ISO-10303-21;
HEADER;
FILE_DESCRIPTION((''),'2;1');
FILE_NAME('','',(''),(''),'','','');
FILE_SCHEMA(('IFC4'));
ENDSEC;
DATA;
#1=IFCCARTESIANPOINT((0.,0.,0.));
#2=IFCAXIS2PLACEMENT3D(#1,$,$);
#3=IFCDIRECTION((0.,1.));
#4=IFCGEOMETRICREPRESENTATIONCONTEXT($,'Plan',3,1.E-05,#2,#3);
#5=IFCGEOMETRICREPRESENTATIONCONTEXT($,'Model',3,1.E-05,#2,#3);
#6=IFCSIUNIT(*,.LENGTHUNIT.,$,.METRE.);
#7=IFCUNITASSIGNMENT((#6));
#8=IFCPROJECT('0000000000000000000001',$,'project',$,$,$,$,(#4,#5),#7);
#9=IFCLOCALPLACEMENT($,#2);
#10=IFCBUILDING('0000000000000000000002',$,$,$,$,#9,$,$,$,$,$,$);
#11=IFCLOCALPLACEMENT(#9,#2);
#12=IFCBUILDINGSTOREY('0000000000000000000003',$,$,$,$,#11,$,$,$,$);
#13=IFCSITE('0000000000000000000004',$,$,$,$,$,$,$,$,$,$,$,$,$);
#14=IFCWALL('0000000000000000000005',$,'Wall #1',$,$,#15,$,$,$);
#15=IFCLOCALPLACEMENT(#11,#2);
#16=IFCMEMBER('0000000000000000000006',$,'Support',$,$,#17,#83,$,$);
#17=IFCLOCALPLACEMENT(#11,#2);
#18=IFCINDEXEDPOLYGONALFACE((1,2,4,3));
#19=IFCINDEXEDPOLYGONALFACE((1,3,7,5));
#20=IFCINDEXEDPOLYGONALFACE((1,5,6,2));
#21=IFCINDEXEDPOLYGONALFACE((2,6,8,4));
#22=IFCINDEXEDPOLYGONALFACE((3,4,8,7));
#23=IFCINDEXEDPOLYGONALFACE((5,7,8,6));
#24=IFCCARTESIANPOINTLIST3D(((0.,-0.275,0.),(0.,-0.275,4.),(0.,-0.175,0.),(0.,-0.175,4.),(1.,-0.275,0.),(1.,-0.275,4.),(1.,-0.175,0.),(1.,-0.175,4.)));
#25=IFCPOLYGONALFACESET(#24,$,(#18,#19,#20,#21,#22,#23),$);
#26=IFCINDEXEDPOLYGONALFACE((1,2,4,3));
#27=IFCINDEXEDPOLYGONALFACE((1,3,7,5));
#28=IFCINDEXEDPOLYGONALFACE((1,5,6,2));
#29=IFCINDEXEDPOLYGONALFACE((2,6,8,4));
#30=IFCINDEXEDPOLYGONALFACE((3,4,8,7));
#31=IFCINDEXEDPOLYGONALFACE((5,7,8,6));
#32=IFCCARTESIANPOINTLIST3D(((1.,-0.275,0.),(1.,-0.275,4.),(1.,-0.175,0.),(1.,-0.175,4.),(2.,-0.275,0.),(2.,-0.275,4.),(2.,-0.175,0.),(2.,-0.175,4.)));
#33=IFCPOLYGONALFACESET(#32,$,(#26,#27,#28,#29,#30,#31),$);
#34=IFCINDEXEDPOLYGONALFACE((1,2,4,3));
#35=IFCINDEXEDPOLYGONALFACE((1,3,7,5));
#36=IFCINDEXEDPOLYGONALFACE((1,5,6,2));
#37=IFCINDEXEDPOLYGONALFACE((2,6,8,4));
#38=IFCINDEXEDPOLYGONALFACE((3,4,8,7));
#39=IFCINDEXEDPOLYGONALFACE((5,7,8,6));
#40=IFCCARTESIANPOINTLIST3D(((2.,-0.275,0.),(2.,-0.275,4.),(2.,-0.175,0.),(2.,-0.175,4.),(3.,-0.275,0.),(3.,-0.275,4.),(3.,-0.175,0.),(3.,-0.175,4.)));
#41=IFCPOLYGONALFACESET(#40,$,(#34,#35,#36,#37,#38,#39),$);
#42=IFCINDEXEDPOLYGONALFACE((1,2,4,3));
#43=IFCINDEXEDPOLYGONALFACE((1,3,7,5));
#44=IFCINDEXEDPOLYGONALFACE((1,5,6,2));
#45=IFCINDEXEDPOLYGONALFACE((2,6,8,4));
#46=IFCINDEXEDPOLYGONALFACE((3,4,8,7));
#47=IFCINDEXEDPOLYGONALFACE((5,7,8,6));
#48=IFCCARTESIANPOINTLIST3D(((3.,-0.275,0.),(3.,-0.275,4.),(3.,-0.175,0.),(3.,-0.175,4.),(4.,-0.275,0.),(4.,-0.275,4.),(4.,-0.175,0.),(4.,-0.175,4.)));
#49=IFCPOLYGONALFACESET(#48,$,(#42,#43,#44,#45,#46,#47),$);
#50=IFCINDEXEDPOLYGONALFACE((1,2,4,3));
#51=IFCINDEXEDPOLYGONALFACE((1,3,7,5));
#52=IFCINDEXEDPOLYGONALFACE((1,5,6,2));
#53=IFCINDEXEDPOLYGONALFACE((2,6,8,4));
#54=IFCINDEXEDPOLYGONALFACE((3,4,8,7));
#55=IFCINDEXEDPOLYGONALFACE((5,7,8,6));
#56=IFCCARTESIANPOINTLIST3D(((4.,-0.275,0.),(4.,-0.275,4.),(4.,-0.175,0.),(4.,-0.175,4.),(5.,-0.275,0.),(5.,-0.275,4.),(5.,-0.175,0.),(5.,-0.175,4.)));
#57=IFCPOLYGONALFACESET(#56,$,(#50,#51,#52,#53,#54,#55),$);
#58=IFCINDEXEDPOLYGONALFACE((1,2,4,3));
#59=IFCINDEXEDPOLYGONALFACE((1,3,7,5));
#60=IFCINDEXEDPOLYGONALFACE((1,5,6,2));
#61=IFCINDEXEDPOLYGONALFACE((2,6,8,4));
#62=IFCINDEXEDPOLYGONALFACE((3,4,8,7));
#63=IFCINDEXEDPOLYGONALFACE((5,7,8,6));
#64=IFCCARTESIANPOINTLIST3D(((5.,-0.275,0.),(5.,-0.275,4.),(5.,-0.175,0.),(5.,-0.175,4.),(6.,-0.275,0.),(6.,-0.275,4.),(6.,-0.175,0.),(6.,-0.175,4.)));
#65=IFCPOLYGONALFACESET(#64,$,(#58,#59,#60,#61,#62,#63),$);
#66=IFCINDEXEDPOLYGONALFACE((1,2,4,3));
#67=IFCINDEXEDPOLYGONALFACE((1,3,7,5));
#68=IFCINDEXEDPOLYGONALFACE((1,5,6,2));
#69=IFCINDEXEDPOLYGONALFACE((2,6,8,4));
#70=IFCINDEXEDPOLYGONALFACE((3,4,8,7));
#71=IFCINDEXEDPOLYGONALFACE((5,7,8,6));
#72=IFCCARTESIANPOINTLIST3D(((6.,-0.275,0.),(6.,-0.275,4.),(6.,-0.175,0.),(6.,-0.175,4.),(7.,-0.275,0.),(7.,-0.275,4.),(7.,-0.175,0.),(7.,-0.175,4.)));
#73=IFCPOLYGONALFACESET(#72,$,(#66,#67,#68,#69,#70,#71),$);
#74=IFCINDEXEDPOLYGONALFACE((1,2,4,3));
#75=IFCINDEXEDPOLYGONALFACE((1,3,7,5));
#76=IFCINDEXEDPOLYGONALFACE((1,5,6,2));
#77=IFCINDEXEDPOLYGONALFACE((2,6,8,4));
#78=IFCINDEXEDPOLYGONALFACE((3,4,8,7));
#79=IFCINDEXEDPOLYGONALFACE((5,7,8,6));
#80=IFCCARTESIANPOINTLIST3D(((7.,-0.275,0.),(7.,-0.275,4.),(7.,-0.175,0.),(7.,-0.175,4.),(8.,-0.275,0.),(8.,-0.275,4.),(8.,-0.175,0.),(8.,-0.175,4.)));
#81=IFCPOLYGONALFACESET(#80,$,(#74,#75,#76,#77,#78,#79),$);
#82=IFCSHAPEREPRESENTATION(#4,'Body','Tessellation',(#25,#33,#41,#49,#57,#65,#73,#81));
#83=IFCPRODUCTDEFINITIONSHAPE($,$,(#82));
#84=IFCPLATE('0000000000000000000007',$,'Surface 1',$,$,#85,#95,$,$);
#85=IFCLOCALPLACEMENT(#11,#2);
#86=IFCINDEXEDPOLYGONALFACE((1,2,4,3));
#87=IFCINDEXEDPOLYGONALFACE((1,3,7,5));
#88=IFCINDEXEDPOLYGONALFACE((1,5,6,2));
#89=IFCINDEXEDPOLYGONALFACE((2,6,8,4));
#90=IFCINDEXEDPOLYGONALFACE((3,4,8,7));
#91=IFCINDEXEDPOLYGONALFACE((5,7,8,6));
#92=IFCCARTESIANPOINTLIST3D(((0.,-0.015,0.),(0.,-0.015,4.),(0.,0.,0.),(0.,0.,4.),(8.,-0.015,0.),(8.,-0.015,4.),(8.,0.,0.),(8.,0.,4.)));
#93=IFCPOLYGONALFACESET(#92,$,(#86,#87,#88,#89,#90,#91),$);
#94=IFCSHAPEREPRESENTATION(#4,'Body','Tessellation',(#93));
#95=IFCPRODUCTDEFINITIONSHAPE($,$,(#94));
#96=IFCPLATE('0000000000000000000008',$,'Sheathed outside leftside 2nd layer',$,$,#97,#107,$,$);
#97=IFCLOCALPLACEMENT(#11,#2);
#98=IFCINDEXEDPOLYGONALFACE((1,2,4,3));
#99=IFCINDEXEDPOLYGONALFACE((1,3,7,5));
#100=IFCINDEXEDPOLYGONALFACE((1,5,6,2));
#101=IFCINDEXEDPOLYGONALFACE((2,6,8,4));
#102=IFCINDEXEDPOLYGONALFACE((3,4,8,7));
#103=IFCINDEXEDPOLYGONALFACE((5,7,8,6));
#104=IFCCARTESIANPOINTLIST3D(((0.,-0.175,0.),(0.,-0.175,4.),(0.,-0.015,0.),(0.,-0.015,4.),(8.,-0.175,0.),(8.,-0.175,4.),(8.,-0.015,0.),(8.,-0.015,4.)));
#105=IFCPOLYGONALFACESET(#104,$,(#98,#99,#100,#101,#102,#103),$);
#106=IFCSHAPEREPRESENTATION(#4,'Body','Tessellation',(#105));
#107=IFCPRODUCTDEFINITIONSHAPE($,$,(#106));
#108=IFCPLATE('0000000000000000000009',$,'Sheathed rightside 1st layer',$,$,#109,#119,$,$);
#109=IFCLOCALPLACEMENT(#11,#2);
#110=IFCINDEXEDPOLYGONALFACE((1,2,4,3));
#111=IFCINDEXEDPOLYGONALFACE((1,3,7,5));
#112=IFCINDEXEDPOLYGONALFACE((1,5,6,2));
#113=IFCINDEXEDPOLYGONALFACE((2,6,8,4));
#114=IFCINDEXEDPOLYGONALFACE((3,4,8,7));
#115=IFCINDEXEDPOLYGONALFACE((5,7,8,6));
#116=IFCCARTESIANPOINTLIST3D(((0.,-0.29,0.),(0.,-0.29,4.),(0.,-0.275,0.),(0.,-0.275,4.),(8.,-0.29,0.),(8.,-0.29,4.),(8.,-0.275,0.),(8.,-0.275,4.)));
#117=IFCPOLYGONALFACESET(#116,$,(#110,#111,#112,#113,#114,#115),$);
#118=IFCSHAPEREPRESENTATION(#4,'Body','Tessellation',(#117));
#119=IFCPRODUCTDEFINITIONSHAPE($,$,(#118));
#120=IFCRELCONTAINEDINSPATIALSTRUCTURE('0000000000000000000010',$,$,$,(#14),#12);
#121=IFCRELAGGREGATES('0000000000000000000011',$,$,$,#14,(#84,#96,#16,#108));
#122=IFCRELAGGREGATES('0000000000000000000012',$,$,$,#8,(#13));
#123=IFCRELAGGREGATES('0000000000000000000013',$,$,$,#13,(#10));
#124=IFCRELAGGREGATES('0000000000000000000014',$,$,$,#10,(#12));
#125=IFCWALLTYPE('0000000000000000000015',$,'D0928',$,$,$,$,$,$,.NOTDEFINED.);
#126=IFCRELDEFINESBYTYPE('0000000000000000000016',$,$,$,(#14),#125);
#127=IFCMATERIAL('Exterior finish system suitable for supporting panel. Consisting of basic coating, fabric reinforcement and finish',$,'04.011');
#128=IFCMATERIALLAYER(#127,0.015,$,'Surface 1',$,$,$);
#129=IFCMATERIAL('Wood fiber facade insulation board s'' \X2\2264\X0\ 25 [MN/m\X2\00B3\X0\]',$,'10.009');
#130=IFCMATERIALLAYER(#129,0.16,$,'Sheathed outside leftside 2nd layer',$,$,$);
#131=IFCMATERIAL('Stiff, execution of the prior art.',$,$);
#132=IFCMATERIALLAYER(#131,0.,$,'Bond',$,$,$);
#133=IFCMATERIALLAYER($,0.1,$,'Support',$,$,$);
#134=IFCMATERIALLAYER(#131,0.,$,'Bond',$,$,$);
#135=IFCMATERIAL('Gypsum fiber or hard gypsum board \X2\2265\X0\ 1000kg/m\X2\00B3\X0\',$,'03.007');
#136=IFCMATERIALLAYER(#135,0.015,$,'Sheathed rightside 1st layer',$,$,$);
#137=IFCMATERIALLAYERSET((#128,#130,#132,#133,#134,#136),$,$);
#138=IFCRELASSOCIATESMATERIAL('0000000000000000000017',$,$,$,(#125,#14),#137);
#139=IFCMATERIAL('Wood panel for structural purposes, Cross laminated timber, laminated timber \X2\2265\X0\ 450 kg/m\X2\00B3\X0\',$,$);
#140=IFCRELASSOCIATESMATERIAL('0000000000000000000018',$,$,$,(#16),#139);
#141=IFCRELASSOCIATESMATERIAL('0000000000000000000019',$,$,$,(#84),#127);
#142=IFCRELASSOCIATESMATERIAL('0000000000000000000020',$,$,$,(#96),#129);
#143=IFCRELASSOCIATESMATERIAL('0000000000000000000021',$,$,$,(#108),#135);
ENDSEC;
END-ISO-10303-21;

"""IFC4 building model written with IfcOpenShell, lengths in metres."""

from ifc_helpers import new_model, si_unit, direction, frame, frame_2d, origin, origin_with_axes, place, context, project, spatial, rectangle, extrude, material, layer, layer_set, type_object, element, aggregate, save


model = new_model("IFC4")

# Units and contexts
plan_context = context("Plan", 3, precision=1e-05, world=origin(), true_north=direction((0.0, 1.0)))
model_context = context("Model", 3, precision=1e-05, world=origin(), true_north=direction((0.0, 1.0)))
ifc_project = project(units=[si_unit("LENGTHUNIT", "METRE")], contexts=[plan_context, model_context])

# Site, building, storey
site = spatial("IfcSite", under=ifc_project)
building_placement = place(None, origin())
building = spatial("IfcBuilding", under=site, at=building_placement)
storey_placement = place(building_placement, origin())
storey = spatial("IfcBuildingStorey", under=building, at=storey_placement)

# Wall, member, plates
ifc_material_1 = material(Name="Exterior finish system suitable for supporting panel. Consisting of basic coating, fabric reinforcement and finish", Category="04.011")
ifc_layer_1 = layer(ifc_material_1, 0.015, Name="Surface 1")
ifc_material_2 = material(Name="Wood fiber facade insulation board s' ≤ 25 [MN/m³]", Category="10.009")
ifc_layer_2 = layer(ifc_material_2, 0.16, Name="Sheathed outside leftside 2nd layer")
ifc_material_3 = material(Name="Stiff, execution of the prior art.")
ifc_layer_3 = layer(ifc_material_3, 0.0, Name="Bond")
ifc_layer_4 = layer(None, 0.1, Name="Support")
ifc_layer_5 = layer(ifc_material_3, 0.0, Name="Bond")
ifc_material_4 = material(Name="Gypsum fiber or hard gypsum board ≥ 1000kg/m³", Category="03.007")
ifc_layer_6 = layer(ifc_material_4, 0.015, Name="Sheathed rightside 1st layer")
ifc_layer_set = layer_set([ifc_layer_1, ifc_layer_2, ifc_layer_3, ifc_layer_4, ifc_layer_5, ifc_layer_6])
wall_type = type_object("IfcWallType", Name="D0928", PredefinedType="NOTDEFINED", material=ifc_layer_set)
wall_placement = place(None, frame((0.0, 0.0, 0.0), z_axis=(0.0, -1.0, 0.0), x_axis=(1.0, 0.0, 0.0)))
wall = element("IfcWall", 1, at=wall_placement, inside=storey, type_object=wall_type, material=ifc_layer_set, Name="Wall #1")
ifc_material_5 = material(Name="Wood panel for structural purposes, Cross laminated timber, laminated timber ≥ 450 kg/m³")
member_placement = place(wall_placement, origin())
member = element("IfcMember", 2, at=member_placement, material=ifc_material_5, Name="Support", context=plan_context, shape_type="SweptSolid", body=[
    extrude(rectangle(XDim=1.0, YDim=0.1, at=frame_2d((0.5, 0.05), x_axis=(1.0, 0.0))), frame((0.0, 4.0, 0.175), z_axis=(0.0, -1.0, 0.0), x_axis=(1.0, 0.0, 0.0)), (0.0, 0.0, 1.0), 4.0),
    extrude(rectangle(XDim=1.0, YDim=0.1, at=frame_2d((0.5, 0.05), x_axis=(1.0, 0.0))), frame((1.0, 4.0, 0.175), z_axis=(0.0, -1.0, 0.0), x_axis=(1.0, 0.0, 0.0)), (0.0, 0.0, 1.0), 4.0),
    extrude(rectangle(XDim=1.0, YDim=0.1, at=frame_2d((0.5, 0.05), x_axis=(1.0, 0.0))), frame((2.0, 4.0, 0.175), z_axis=(0.0, -1.0, 0.0), x_axis=(1.0, 0.0, 0.0)), (0.0, 0.0, 1.0), 4.0),
    extrude(rectangle(XDim=1.0, YDim=0.1, at=frame_2d((0.5, 0.05), x_axis=(1.0, 0.0))), frame((3.0, 4.0, 0.175), z_axis=(0.0, -1.0, 0.0), x_axis=(1.0, 0.0, 0.0)), (0.0, 0.0, 1.0), 4.0),
    extrude(rectangle(XDim=1.0, YDim=0.1, at=frame_2d((0.5, 0.05), x_axis=(1.0, 0.0))), frame((4.0, 4.0, 0.175), z_axis=(0.0, -1.0, 0.0), x_axis=(1.0, 0.0, 0.0)), (0.0, 0.0, 1.0), 4.0),
    extrude(rectangle(XDim=1.0, YDim=0.1, at=frame_2d((0.5, 0.05), x_axis=(1.0, 0.0))), frame((5.0, 4.0, 0.175), z_axis=(0.0, -1.0, 0.0), x_axis=(1.0, 0.0, 0.0)), (0.0, 0.0, 1.0), 4.0),
    extrude(rectangle(XDim=1.0, YDim=0.1, at=frame_2d((0.5, 0.05), x_axis=(1.0, 0.0))), frame((6.0, 4.0, 0.175), z_axis=(0.0, -1.0, 0.0), x_axis=(1.0, 0.0, 0.0)), (0.0, 0.0, 1.0), 4.0),
    extrude(rectangle(XDim=1.0, YDim=0.1, at=frame_2d((0.5, 0.05), x_axis=(1.0, 0.0))), frame((7.0, 4.0, 0.175), z_axis=(0.0, -1.0, 0.0), x_axis=(1.0, 0.0, 0.0)), (0.0, 0.0, 1.0), 4.0),
])
plate_1_placement = place(wall_placement, origin())
plate_1 = element("IfcPlate", 3, at=plate_1_placement, material=ifc_material_1, Name="Surface 1", context=plan_context, shape_type="SweptSolid", body=[
    extrude(rectangle(XDim=8.0, YDim=4.0, at=frame_2d((4.0, 2.0), x_axis=(1.0, 0.0))), origin_with_axes(), (0.0, 0.0, 1.0), 0.015),
])
plate_2_placement = place(wall_placement, origin())
plate_2 = element("IfcPlate", 4, at=plate_2_placement, material=ifc_material_2, Name="Sheathed outside leftside 2nd layer", context=plan_context, shape_type="SweptSolid", body=[
    extrude(rectangle(XDim=8.0, YDim=4.0, at=frame_2d((4.0, 2.0), x_axis=(1.0, 0.0))), frame((0.0, 0.0, 0.015), z_axis=(0.0, 0.0, 1.0), x_axis=(1.0, 0.0, 0.0)), (0.0, 0.0, 1.0), 0.16),
])
plate_3_placement = place(wall_placement, origin())
plate_3 = element("IfcPlate", 5, at=plate_3_placement, material=ifc_material_4, Name="Sheathed rightside 1st layer", context=plan_context, shape_type="SweptSolid", body=[
    extrude(rectangle(XDim=8.0, YDim=4.0, at=frame_2d((4.0, 2.0), x_axis=(1.0, 0.0))), frame((0.0, 0.0, 0.275), z_axis=(0.0, 0.0, 1.0), x_axis=(1.0, 0.0, 0.0)), (0.0, 0.0, 1.0), 0.015),
])
aggregate(wall, [plate_1, plate_2, member, plate_3])

save(model, "model.ifc")
